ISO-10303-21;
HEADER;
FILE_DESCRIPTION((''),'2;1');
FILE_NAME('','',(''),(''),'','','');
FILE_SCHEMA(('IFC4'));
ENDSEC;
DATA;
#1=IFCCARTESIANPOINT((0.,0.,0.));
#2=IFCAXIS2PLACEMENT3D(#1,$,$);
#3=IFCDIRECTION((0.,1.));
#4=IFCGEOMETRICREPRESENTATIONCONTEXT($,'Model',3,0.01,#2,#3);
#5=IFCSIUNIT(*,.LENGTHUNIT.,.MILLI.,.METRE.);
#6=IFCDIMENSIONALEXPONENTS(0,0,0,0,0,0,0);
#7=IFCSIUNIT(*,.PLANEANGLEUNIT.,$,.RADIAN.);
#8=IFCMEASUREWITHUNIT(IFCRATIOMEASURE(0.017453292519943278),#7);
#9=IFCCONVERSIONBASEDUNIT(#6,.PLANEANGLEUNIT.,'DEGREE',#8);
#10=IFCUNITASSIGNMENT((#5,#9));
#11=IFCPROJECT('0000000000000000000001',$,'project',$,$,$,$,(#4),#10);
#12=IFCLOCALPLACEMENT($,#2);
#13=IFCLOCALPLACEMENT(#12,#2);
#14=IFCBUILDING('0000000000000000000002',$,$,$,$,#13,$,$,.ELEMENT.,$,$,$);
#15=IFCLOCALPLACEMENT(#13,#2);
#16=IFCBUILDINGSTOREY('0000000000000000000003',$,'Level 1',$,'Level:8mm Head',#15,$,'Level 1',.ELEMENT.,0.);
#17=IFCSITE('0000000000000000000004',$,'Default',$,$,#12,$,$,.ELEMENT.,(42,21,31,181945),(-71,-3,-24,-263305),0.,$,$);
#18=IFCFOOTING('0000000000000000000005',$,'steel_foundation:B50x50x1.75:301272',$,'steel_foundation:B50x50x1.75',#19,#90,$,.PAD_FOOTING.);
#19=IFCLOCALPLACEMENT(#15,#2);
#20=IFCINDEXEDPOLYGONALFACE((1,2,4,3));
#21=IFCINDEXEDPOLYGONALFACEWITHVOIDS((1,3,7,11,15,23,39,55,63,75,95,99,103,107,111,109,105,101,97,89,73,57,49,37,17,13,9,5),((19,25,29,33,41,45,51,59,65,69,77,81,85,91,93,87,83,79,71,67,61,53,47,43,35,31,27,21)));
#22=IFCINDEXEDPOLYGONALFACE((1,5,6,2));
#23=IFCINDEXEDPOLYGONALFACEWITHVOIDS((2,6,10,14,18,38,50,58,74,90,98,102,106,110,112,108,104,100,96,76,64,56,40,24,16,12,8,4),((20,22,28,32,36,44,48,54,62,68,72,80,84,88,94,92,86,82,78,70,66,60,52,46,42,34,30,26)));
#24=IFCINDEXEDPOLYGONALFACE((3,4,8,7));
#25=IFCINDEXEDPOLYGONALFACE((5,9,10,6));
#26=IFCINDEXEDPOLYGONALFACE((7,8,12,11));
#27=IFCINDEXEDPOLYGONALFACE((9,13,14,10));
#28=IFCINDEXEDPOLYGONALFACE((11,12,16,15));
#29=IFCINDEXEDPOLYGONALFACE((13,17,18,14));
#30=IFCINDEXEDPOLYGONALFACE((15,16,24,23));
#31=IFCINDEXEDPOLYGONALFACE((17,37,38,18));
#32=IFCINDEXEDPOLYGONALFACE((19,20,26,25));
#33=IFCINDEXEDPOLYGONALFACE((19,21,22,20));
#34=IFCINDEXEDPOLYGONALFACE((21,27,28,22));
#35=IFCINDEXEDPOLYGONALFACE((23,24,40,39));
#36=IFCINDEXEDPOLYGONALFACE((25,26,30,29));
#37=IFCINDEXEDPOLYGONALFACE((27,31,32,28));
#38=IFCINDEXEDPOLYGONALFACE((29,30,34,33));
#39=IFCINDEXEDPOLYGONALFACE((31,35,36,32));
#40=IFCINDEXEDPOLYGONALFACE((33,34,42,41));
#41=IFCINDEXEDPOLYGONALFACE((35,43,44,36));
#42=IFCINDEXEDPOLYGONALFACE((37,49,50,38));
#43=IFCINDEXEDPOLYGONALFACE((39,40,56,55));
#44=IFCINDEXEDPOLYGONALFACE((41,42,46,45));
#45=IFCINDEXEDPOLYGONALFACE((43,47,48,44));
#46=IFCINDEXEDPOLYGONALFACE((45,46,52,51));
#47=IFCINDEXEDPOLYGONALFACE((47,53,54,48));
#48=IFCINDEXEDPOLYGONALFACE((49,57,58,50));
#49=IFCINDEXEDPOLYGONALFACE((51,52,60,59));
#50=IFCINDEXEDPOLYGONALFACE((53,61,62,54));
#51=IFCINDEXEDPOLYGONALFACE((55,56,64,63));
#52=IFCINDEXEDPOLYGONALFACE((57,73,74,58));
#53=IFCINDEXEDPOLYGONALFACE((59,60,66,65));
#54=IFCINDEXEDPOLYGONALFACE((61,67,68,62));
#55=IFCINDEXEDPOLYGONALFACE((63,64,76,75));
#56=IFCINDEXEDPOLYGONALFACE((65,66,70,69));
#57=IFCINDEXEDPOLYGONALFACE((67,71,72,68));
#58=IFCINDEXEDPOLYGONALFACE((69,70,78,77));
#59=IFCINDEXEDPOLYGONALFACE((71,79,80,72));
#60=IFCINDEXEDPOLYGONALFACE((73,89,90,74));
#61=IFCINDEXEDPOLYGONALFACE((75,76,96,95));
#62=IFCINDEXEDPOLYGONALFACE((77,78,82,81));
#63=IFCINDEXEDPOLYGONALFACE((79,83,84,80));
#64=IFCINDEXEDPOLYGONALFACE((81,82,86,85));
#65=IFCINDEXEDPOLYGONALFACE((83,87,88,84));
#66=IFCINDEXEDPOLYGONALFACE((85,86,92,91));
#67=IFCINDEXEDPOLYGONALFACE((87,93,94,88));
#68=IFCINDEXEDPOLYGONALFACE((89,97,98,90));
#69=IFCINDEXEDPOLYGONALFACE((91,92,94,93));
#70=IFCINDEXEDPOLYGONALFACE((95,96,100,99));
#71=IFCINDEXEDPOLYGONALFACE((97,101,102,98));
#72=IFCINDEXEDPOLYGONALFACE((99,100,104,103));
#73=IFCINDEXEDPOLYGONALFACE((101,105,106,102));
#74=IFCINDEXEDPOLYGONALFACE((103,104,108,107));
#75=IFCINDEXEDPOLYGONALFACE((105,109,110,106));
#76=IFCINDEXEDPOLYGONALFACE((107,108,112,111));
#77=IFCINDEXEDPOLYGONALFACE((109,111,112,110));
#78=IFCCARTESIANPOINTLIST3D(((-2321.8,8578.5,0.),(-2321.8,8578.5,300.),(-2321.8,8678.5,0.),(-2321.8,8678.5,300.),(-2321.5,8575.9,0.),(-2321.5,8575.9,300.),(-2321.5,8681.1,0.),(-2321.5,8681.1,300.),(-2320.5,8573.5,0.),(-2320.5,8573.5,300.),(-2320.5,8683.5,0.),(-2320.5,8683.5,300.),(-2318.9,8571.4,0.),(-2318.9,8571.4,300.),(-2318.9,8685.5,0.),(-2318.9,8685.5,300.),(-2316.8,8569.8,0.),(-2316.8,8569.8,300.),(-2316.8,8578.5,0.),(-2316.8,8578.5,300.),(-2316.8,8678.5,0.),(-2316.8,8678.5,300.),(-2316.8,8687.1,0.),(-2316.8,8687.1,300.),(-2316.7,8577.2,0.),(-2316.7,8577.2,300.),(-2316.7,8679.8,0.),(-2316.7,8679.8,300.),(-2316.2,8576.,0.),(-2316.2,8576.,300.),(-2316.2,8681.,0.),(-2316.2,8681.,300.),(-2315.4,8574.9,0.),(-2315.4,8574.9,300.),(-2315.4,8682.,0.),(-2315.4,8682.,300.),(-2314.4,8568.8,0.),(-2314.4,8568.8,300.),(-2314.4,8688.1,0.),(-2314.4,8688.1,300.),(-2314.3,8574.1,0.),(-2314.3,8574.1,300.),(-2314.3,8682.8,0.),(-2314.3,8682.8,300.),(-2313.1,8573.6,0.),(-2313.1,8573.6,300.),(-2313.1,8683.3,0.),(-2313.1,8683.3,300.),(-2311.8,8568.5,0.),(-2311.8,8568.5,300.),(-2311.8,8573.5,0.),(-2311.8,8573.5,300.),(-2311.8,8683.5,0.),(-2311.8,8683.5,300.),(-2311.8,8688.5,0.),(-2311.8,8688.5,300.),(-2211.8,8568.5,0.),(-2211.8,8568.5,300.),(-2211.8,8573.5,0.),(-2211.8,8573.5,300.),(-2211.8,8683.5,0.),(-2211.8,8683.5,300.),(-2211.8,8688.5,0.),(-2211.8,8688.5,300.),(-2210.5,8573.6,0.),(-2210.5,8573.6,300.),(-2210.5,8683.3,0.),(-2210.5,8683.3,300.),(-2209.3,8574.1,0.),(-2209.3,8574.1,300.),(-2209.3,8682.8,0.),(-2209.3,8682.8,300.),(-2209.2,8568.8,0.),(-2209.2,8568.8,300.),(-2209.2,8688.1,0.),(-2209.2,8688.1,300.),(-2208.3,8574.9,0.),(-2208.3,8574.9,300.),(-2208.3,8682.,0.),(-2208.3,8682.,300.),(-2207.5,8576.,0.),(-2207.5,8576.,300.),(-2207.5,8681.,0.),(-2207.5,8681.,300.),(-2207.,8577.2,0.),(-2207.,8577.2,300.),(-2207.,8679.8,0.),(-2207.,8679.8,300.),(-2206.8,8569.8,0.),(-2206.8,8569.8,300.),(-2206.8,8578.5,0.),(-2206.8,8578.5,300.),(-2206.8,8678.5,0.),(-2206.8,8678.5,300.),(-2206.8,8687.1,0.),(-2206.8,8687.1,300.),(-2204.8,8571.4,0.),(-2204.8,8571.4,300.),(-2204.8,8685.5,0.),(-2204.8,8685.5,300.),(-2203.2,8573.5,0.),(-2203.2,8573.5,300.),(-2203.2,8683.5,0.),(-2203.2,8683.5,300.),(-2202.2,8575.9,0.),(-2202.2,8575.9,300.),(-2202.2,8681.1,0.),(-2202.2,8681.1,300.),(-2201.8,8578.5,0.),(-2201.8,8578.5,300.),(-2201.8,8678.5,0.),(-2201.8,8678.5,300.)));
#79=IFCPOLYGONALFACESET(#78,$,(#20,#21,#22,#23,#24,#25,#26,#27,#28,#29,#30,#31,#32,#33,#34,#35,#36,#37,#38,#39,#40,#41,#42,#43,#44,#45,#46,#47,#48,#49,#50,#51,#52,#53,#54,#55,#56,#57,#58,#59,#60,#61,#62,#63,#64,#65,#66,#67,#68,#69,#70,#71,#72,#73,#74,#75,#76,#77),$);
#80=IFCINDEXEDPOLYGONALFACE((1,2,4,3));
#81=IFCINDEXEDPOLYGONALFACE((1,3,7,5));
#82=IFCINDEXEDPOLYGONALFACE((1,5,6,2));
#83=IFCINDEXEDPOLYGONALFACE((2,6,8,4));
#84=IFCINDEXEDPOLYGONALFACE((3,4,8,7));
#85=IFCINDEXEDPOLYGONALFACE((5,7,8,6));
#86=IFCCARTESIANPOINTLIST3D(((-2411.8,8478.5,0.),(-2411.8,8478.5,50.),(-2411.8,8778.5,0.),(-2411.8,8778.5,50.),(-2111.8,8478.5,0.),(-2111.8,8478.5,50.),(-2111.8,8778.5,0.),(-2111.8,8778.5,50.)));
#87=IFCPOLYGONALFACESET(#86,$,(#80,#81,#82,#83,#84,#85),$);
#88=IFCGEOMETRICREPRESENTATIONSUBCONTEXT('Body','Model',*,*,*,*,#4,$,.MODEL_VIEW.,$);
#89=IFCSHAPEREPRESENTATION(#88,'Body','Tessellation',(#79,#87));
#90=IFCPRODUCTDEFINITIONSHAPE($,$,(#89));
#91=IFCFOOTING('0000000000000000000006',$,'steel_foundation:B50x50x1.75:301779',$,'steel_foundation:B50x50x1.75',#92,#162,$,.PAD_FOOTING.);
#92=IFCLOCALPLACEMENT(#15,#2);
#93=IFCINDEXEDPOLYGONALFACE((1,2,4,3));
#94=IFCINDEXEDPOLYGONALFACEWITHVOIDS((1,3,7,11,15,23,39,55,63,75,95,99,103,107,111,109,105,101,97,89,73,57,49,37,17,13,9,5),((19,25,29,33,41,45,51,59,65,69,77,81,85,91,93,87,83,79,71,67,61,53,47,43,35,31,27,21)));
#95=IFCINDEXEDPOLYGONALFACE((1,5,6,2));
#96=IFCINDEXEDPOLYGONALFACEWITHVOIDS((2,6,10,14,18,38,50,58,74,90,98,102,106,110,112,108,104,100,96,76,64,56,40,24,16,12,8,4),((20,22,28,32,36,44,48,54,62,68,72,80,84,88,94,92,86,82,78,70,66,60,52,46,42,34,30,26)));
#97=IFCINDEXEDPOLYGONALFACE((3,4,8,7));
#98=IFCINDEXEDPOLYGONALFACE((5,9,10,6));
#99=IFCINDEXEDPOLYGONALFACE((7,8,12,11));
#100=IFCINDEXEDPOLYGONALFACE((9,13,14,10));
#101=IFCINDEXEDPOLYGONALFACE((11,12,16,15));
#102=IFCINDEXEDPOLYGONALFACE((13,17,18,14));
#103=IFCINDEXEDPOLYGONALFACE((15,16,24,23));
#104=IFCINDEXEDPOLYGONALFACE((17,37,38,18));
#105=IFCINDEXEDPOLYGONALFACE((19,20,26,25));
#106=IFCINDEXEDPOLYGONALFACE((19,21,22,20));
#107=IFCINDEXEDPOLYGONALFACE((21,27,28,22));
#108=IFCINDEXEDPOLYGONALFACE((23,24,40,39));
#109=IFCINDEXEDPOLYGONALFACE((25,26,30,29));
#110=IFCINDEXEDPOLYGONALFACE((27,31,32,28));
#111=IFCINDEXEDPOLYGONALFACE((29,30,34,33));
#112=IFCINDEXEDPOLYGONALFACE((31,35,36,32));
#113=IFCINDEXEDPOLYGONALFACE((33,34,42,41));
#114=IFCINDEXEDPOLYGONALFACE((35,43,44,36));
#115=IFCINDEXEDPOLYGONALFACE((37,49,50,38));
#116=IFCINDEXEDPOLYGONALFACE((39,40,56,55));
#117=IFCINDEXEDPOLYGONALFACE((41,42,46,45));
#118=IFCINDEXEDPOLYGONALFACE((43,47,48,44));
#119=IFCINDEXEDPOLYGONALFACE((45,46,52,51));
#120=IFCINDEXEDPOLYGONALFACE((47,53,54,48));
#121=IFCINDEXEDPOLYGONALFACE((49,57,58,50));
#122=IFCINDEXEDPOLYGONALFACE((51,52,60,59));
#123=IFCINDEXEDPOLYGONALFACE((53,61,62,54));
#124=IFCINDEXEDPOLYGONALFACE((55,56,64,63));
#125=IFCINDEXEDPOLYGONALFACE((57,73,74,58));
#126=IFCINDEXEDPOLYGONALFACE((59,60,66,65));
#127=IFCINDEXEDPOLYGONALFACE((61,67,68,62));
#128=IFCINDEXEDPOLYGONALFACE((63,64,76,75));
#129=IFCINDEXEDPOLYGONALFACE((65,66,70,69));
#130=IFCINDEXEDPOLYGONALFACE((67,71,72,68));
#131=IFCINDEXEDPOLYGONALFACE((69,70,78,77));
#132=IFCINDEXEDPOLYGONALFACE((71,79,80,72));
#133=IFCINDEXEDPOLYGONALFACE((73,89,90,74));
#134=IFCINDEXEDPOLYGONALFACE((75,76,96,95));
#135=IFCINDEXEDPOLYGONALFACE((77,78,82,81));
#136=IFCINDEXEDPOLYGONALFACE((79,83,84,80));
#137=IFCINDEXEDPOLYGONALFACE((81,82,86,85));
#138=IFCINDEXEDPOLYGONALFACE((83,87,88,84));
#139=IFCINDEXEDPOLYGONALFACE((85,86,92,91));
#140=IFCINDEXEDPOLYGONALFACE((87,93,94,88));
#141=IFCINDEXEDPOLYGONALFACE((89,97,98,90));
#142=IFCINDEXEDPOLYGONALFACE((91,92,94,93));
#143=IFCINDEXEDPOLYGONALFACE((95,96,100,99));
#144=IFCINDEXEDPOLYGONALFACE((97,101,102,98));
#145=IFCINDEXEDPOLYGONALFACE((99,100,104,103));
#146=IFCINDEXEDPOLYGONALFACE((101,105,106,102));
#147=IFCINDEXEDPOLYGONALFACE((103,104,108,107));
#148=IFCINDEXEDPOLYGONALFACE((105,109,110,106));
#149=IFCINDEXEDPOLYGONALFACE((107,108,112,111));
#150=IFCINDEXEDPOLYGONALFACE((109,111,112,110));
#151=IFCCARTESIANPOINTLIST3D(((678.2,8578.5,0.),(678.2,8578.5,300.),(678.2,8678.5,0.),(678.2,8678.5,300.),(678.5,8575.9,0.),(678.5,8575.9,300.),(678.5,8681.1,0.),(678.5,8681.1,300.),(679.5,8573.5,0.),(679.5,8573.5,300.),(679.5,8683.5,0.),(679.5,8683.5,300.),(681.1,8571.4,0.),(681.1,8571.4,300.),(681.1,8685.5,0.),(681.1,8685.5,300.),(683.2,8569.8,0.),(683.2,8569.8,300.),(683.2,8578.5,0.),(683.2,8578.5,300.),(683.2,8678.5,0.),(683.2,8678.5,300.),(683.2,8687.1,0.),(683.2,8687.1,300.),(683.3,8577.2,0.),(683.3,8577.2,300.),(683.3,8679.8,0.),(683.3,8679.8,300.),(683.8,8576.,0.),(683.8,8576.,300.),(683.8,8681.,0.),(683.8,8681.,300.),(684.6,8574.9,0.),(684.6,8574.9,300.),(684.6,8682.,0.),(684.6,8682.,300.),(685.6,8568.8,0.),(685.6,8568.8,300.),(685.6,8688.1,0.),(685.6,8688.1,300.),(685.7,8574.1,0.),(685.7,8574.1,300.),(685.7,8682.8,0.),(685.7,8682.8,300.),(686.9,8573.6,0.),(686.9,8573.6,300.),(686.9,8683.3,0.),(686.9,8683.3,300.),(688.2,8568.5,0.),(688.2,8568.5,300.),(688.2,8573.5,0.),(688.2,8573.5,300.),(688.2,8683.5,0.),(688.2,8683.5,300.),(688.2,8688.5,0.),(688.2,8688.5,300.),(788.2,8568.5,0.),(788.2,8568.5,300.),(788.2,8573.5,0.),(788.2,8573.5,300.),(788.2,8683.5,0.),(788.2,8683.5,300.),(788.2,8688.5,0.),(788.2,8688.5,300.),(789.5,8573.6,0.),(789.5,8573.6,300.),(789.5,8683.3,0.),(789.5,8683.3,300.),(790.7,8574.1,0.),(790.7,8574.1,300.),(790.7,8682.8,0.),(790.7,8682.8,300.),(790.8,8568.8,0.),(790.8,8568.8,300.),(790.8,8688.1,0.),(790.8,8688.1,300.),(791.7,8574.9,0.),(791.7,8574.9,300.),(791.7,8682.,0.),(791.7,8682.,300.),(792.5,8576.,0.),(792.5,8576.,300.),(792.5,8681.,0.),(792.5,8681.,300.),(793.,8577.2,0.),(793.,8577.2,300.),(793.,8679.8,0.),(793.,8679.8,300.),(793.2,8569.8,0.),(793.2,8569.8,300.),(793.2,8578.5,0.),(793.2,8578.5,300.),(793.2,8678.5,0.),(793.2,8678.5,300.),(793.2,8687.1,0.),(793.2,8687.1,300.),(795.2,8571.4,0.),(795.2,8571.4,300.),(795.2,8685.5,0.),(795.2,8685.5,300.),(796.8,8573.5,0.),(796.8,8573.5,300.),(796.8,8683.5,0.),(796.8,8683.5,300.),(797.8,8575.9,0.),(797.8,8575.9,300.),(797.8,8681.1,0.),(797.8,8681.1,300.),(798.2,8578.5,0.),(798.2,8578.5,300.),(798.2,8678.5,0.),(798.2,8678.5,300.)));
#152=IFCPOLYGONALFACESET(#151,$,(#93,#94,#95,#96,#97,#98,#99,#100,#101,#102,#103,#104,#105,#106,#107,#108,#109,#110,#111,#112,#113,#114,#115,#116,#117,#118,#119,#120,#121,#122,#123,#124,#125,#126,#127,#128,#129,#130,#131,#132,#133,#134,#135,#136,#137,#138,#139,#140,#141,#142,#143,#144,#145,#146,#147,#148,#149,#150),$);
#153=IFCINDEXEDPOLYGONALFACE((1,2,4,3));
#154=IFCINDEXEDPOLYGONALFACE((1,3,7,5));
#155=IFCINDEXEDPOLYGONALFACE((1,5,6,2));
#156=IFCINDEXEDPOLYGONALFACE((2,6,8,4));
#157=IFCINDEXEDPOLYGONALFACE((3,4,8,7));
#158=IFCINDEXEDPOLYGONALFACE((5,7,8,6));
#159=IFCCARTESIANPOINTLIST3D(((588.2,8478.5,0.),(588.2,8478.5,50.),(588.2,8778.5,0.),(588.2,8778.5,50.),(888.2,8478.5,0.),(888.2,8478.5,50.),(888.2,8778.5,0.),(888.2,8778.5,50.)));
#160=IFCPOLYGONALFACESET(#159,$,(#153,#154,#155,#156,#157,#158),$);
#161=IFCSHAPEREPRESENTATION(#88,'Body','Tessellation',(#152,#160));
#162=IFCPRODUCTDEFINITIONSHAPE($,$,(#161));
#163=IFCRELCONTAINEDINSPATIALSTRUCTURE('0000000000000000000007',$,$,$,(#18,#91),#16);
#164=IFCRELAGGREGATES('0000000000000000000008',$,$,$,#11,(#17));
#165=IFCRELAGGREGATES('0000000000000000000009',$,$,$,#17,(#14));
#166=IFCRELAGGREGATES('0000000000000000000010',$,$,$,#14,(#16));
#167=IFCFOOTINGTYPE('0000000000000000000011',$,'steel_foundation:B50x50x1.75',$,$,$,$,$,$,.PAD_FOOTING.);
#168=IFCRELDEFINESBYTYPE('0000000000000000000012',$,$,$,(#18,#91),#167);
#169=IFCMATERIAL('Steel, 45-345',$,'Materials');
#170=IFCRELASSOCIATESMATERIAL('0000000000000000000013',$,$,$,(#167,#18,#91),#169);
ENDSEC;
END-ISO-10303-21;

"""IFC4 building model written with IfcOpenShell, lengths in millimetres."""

from ifc_helpers import new_model, entity, si_unit, converted_unit, direction, frame, frame_2d, origin, place, context, subcontext, project, spatial, polyline, circle_curve, parameter, trimmed, segment, composite_curve, rectangle, outline, extrude, source, transform, mapped, material, type_object, type_shapes, element, save


model = new_model("IFC4")

# Units and contexts
model_context = context("Model", 3, precision=0.01, world=origin(), true_north=direction((0.0, 1.0)))
body_context = subcontext(model_context, "Body", "Model", "MODEL_VIEW")
ifc_project = project(units=[si_unit("LENGTHUNIT", "METRE", prefix="MILLI"), converted_unit("PLANEANGLEUNIT", "DEGREE", entity("IfcRatioMeasure", 0.017453292519943278), si_unit("PLANEANGLEUNIT", "RADIAN"), dimensions=[0, 0, 0, 0, 0, 0, 0])], contexts=[model_context])

# Site, building, storey
site_placement = place(None, origin())
site = spatial("IfcSite", under=ifc_project, at=site_placement, Name="Default", CompositionType="ELEMENT", RefLatitude=(42, 21, 31, 181945), RefLongitude=(-71, -3, -24, -263305), RefElevation=0.0)
building_placement = place(site_placement, origin())
building = spatial("IfcBuilding", under=site, at=building_placement, CompositionType="ELEMENT")
storey_placement = place(building_placement, origin())
storey = spatial("IfcBuildingStorey", under=building, at=storey_placement, Name="Level 1", ObjectType="Level:8mm Head", LongName="Level 1", CompositionType="ELEMENT", Elevation=0.0)

# Footings
ifc_material_1 = material(Name="Steel, 45-345", Category="Materials")
footing_type = type_object("IfcFootingType", Name="steel_foundation:B50x50x1.75", PredefinedType="PAD_FOOTING", material=ifc_material_1)
shared_shape_1 = source(origin(), body_context, "Body", "SweptSolid", [
    extrude(outline(composite_curve([segment(polyline([(-50.0, -60.0), (50.0, -60.0)]), True, "CONTINUOUS"), segment(trimmed(circle_curve(frame_2d((50.0, -50.0), x_axis=(-1.0, 0.0)), 10.0), [parameter(90.0)], [parameter(180.0)], True, "PARAMETER"), True, "CONTINUOUS"), segment(polyline([(60.0, -50.0), (60.0, 50.0)]), True, "CONTINUOUS"), segment(trimmed(circle_curve(frame_2d((50.0, 50.0), x_axis=(-1.0, 0.0)), 10.0), [parameter(180.0)], [parameter(270.0)], True, "PARAMETER"), True, "CONTINUOUS"), segment(polyline([(50.0, 60.0), (-50.0, 60.0)]), True, "CONTINUOUS"), segment(trimmed(circle_curve(frame_2d((-50.0, 50.0), x_axis=(-1.0, 0.0)), 10.0), [parameter(270.0)], [parameter(360.0)], True, "PARAMETER"), True, "CONTINUOUS"), segment(polyline([(-60.0, 50.0), (-60.0, -50.0)]), True, "CONTINUOUS"), segment(trimmed(circle_curve(frame_2d((-50.0, -50.0), x_axis=(-1.0, 0.0)), 10.0), [parameter(360.0)], [parameter(90.0)], True, "PARAMETER"), True, "CONTINUOUS")], self_intersect=False), holes=[composite_curve([segment(trimmed(circle_curve(frame_2d((-50.0, -50.0), x_axis=(-1.0, 0.0)), 5.0), [parameter(0.0)], [parameter(90.0)], True, "PARAMETER"), False, "CONTINUOUS"), segment(polyline([(-55.0, -50.0), (-55.0, 50.0)]), True, "CONTINUOUS"), segment(trimmed(circle_curve(frame_2d((-50.0, 50.0), x_axis=(-1.0, 0.0)), 5.0), [parameter(270.0)], [parameter(360.0)], True, "PARAMETER"), False, "CONTINUOUS"), segment(polyline([(-50.0, 55.0), (50.0, 55.0)]), True, "CONTINUOUS"), segment(trimmed(circle_curve(frame_2d((50.0, 50.0), x_axis=(-1.0, 0.0)), 5.0), [parameter(180.0)], [parameter(270.0)], True, "PARAMETER"), False, "CONTINUOUS"), segment(polyline([(55.0, 50.0), (55.0, -50.0)]), True, "CONTINUOUS"), segment(trimmed(circle_curve(frame_2d((50.0, -50.0), x_axis=(-1.0, 0.0)), 5.0), [parameter(90.0)], [parameter(180.0)], True, "PARAMETER"), False, "CONTINUOUS"), segment(polyline([(50.0, -55.0), (-50.0, -55.0)]), True, "CONTINUOUS")], self_intersect=False)]), frame((0.0, 0.0, 0.0), z_axis=(0.0, 0.0, 1.0), x_axis=(-1.0, 0.0, 0.0)), (0.0, 0.0, 1.0), 300.0),
    extrude(rectangle(XDim=300.0, YDim=300.0, at=frame_2d((0.0, 0.0), x_axis=(1.0, 0.0))), frame((0.0, 0.0, 0.0), z_axis=(0.0, 0.0, 1.0), x_axis=(-1.0, 0.0, 0.0)), (0.0, 0.0, 1.0), 50.0),
])
type_shapes(footing_type, [shared_shape_1])
for number, where, name in (
    (1, (-2261.8, 8628.5, 0.0), "steel_foundation:B50x50x1.75:301272"),
    (2, (738.2, 8628.5, 0.0), "steel_foundation:B50x50x1.75:301779"),
):
    element("IfcFooting", number, at=place(storey_placement, frame(where)), inside=storey, type_object=footing_type, material=ifc_material_1, Name=name, ObjectType="steel_foundation:B50x50x1.75", PredefinedType="PAD_FOOTING", context=body_context, shape_type="MappedRepresentation", body=[
        mapped(shared_shape_1, transform((0.0, 0.0, 0.0), scale=1.0)),
    ])

save(model, "model.ifc")
